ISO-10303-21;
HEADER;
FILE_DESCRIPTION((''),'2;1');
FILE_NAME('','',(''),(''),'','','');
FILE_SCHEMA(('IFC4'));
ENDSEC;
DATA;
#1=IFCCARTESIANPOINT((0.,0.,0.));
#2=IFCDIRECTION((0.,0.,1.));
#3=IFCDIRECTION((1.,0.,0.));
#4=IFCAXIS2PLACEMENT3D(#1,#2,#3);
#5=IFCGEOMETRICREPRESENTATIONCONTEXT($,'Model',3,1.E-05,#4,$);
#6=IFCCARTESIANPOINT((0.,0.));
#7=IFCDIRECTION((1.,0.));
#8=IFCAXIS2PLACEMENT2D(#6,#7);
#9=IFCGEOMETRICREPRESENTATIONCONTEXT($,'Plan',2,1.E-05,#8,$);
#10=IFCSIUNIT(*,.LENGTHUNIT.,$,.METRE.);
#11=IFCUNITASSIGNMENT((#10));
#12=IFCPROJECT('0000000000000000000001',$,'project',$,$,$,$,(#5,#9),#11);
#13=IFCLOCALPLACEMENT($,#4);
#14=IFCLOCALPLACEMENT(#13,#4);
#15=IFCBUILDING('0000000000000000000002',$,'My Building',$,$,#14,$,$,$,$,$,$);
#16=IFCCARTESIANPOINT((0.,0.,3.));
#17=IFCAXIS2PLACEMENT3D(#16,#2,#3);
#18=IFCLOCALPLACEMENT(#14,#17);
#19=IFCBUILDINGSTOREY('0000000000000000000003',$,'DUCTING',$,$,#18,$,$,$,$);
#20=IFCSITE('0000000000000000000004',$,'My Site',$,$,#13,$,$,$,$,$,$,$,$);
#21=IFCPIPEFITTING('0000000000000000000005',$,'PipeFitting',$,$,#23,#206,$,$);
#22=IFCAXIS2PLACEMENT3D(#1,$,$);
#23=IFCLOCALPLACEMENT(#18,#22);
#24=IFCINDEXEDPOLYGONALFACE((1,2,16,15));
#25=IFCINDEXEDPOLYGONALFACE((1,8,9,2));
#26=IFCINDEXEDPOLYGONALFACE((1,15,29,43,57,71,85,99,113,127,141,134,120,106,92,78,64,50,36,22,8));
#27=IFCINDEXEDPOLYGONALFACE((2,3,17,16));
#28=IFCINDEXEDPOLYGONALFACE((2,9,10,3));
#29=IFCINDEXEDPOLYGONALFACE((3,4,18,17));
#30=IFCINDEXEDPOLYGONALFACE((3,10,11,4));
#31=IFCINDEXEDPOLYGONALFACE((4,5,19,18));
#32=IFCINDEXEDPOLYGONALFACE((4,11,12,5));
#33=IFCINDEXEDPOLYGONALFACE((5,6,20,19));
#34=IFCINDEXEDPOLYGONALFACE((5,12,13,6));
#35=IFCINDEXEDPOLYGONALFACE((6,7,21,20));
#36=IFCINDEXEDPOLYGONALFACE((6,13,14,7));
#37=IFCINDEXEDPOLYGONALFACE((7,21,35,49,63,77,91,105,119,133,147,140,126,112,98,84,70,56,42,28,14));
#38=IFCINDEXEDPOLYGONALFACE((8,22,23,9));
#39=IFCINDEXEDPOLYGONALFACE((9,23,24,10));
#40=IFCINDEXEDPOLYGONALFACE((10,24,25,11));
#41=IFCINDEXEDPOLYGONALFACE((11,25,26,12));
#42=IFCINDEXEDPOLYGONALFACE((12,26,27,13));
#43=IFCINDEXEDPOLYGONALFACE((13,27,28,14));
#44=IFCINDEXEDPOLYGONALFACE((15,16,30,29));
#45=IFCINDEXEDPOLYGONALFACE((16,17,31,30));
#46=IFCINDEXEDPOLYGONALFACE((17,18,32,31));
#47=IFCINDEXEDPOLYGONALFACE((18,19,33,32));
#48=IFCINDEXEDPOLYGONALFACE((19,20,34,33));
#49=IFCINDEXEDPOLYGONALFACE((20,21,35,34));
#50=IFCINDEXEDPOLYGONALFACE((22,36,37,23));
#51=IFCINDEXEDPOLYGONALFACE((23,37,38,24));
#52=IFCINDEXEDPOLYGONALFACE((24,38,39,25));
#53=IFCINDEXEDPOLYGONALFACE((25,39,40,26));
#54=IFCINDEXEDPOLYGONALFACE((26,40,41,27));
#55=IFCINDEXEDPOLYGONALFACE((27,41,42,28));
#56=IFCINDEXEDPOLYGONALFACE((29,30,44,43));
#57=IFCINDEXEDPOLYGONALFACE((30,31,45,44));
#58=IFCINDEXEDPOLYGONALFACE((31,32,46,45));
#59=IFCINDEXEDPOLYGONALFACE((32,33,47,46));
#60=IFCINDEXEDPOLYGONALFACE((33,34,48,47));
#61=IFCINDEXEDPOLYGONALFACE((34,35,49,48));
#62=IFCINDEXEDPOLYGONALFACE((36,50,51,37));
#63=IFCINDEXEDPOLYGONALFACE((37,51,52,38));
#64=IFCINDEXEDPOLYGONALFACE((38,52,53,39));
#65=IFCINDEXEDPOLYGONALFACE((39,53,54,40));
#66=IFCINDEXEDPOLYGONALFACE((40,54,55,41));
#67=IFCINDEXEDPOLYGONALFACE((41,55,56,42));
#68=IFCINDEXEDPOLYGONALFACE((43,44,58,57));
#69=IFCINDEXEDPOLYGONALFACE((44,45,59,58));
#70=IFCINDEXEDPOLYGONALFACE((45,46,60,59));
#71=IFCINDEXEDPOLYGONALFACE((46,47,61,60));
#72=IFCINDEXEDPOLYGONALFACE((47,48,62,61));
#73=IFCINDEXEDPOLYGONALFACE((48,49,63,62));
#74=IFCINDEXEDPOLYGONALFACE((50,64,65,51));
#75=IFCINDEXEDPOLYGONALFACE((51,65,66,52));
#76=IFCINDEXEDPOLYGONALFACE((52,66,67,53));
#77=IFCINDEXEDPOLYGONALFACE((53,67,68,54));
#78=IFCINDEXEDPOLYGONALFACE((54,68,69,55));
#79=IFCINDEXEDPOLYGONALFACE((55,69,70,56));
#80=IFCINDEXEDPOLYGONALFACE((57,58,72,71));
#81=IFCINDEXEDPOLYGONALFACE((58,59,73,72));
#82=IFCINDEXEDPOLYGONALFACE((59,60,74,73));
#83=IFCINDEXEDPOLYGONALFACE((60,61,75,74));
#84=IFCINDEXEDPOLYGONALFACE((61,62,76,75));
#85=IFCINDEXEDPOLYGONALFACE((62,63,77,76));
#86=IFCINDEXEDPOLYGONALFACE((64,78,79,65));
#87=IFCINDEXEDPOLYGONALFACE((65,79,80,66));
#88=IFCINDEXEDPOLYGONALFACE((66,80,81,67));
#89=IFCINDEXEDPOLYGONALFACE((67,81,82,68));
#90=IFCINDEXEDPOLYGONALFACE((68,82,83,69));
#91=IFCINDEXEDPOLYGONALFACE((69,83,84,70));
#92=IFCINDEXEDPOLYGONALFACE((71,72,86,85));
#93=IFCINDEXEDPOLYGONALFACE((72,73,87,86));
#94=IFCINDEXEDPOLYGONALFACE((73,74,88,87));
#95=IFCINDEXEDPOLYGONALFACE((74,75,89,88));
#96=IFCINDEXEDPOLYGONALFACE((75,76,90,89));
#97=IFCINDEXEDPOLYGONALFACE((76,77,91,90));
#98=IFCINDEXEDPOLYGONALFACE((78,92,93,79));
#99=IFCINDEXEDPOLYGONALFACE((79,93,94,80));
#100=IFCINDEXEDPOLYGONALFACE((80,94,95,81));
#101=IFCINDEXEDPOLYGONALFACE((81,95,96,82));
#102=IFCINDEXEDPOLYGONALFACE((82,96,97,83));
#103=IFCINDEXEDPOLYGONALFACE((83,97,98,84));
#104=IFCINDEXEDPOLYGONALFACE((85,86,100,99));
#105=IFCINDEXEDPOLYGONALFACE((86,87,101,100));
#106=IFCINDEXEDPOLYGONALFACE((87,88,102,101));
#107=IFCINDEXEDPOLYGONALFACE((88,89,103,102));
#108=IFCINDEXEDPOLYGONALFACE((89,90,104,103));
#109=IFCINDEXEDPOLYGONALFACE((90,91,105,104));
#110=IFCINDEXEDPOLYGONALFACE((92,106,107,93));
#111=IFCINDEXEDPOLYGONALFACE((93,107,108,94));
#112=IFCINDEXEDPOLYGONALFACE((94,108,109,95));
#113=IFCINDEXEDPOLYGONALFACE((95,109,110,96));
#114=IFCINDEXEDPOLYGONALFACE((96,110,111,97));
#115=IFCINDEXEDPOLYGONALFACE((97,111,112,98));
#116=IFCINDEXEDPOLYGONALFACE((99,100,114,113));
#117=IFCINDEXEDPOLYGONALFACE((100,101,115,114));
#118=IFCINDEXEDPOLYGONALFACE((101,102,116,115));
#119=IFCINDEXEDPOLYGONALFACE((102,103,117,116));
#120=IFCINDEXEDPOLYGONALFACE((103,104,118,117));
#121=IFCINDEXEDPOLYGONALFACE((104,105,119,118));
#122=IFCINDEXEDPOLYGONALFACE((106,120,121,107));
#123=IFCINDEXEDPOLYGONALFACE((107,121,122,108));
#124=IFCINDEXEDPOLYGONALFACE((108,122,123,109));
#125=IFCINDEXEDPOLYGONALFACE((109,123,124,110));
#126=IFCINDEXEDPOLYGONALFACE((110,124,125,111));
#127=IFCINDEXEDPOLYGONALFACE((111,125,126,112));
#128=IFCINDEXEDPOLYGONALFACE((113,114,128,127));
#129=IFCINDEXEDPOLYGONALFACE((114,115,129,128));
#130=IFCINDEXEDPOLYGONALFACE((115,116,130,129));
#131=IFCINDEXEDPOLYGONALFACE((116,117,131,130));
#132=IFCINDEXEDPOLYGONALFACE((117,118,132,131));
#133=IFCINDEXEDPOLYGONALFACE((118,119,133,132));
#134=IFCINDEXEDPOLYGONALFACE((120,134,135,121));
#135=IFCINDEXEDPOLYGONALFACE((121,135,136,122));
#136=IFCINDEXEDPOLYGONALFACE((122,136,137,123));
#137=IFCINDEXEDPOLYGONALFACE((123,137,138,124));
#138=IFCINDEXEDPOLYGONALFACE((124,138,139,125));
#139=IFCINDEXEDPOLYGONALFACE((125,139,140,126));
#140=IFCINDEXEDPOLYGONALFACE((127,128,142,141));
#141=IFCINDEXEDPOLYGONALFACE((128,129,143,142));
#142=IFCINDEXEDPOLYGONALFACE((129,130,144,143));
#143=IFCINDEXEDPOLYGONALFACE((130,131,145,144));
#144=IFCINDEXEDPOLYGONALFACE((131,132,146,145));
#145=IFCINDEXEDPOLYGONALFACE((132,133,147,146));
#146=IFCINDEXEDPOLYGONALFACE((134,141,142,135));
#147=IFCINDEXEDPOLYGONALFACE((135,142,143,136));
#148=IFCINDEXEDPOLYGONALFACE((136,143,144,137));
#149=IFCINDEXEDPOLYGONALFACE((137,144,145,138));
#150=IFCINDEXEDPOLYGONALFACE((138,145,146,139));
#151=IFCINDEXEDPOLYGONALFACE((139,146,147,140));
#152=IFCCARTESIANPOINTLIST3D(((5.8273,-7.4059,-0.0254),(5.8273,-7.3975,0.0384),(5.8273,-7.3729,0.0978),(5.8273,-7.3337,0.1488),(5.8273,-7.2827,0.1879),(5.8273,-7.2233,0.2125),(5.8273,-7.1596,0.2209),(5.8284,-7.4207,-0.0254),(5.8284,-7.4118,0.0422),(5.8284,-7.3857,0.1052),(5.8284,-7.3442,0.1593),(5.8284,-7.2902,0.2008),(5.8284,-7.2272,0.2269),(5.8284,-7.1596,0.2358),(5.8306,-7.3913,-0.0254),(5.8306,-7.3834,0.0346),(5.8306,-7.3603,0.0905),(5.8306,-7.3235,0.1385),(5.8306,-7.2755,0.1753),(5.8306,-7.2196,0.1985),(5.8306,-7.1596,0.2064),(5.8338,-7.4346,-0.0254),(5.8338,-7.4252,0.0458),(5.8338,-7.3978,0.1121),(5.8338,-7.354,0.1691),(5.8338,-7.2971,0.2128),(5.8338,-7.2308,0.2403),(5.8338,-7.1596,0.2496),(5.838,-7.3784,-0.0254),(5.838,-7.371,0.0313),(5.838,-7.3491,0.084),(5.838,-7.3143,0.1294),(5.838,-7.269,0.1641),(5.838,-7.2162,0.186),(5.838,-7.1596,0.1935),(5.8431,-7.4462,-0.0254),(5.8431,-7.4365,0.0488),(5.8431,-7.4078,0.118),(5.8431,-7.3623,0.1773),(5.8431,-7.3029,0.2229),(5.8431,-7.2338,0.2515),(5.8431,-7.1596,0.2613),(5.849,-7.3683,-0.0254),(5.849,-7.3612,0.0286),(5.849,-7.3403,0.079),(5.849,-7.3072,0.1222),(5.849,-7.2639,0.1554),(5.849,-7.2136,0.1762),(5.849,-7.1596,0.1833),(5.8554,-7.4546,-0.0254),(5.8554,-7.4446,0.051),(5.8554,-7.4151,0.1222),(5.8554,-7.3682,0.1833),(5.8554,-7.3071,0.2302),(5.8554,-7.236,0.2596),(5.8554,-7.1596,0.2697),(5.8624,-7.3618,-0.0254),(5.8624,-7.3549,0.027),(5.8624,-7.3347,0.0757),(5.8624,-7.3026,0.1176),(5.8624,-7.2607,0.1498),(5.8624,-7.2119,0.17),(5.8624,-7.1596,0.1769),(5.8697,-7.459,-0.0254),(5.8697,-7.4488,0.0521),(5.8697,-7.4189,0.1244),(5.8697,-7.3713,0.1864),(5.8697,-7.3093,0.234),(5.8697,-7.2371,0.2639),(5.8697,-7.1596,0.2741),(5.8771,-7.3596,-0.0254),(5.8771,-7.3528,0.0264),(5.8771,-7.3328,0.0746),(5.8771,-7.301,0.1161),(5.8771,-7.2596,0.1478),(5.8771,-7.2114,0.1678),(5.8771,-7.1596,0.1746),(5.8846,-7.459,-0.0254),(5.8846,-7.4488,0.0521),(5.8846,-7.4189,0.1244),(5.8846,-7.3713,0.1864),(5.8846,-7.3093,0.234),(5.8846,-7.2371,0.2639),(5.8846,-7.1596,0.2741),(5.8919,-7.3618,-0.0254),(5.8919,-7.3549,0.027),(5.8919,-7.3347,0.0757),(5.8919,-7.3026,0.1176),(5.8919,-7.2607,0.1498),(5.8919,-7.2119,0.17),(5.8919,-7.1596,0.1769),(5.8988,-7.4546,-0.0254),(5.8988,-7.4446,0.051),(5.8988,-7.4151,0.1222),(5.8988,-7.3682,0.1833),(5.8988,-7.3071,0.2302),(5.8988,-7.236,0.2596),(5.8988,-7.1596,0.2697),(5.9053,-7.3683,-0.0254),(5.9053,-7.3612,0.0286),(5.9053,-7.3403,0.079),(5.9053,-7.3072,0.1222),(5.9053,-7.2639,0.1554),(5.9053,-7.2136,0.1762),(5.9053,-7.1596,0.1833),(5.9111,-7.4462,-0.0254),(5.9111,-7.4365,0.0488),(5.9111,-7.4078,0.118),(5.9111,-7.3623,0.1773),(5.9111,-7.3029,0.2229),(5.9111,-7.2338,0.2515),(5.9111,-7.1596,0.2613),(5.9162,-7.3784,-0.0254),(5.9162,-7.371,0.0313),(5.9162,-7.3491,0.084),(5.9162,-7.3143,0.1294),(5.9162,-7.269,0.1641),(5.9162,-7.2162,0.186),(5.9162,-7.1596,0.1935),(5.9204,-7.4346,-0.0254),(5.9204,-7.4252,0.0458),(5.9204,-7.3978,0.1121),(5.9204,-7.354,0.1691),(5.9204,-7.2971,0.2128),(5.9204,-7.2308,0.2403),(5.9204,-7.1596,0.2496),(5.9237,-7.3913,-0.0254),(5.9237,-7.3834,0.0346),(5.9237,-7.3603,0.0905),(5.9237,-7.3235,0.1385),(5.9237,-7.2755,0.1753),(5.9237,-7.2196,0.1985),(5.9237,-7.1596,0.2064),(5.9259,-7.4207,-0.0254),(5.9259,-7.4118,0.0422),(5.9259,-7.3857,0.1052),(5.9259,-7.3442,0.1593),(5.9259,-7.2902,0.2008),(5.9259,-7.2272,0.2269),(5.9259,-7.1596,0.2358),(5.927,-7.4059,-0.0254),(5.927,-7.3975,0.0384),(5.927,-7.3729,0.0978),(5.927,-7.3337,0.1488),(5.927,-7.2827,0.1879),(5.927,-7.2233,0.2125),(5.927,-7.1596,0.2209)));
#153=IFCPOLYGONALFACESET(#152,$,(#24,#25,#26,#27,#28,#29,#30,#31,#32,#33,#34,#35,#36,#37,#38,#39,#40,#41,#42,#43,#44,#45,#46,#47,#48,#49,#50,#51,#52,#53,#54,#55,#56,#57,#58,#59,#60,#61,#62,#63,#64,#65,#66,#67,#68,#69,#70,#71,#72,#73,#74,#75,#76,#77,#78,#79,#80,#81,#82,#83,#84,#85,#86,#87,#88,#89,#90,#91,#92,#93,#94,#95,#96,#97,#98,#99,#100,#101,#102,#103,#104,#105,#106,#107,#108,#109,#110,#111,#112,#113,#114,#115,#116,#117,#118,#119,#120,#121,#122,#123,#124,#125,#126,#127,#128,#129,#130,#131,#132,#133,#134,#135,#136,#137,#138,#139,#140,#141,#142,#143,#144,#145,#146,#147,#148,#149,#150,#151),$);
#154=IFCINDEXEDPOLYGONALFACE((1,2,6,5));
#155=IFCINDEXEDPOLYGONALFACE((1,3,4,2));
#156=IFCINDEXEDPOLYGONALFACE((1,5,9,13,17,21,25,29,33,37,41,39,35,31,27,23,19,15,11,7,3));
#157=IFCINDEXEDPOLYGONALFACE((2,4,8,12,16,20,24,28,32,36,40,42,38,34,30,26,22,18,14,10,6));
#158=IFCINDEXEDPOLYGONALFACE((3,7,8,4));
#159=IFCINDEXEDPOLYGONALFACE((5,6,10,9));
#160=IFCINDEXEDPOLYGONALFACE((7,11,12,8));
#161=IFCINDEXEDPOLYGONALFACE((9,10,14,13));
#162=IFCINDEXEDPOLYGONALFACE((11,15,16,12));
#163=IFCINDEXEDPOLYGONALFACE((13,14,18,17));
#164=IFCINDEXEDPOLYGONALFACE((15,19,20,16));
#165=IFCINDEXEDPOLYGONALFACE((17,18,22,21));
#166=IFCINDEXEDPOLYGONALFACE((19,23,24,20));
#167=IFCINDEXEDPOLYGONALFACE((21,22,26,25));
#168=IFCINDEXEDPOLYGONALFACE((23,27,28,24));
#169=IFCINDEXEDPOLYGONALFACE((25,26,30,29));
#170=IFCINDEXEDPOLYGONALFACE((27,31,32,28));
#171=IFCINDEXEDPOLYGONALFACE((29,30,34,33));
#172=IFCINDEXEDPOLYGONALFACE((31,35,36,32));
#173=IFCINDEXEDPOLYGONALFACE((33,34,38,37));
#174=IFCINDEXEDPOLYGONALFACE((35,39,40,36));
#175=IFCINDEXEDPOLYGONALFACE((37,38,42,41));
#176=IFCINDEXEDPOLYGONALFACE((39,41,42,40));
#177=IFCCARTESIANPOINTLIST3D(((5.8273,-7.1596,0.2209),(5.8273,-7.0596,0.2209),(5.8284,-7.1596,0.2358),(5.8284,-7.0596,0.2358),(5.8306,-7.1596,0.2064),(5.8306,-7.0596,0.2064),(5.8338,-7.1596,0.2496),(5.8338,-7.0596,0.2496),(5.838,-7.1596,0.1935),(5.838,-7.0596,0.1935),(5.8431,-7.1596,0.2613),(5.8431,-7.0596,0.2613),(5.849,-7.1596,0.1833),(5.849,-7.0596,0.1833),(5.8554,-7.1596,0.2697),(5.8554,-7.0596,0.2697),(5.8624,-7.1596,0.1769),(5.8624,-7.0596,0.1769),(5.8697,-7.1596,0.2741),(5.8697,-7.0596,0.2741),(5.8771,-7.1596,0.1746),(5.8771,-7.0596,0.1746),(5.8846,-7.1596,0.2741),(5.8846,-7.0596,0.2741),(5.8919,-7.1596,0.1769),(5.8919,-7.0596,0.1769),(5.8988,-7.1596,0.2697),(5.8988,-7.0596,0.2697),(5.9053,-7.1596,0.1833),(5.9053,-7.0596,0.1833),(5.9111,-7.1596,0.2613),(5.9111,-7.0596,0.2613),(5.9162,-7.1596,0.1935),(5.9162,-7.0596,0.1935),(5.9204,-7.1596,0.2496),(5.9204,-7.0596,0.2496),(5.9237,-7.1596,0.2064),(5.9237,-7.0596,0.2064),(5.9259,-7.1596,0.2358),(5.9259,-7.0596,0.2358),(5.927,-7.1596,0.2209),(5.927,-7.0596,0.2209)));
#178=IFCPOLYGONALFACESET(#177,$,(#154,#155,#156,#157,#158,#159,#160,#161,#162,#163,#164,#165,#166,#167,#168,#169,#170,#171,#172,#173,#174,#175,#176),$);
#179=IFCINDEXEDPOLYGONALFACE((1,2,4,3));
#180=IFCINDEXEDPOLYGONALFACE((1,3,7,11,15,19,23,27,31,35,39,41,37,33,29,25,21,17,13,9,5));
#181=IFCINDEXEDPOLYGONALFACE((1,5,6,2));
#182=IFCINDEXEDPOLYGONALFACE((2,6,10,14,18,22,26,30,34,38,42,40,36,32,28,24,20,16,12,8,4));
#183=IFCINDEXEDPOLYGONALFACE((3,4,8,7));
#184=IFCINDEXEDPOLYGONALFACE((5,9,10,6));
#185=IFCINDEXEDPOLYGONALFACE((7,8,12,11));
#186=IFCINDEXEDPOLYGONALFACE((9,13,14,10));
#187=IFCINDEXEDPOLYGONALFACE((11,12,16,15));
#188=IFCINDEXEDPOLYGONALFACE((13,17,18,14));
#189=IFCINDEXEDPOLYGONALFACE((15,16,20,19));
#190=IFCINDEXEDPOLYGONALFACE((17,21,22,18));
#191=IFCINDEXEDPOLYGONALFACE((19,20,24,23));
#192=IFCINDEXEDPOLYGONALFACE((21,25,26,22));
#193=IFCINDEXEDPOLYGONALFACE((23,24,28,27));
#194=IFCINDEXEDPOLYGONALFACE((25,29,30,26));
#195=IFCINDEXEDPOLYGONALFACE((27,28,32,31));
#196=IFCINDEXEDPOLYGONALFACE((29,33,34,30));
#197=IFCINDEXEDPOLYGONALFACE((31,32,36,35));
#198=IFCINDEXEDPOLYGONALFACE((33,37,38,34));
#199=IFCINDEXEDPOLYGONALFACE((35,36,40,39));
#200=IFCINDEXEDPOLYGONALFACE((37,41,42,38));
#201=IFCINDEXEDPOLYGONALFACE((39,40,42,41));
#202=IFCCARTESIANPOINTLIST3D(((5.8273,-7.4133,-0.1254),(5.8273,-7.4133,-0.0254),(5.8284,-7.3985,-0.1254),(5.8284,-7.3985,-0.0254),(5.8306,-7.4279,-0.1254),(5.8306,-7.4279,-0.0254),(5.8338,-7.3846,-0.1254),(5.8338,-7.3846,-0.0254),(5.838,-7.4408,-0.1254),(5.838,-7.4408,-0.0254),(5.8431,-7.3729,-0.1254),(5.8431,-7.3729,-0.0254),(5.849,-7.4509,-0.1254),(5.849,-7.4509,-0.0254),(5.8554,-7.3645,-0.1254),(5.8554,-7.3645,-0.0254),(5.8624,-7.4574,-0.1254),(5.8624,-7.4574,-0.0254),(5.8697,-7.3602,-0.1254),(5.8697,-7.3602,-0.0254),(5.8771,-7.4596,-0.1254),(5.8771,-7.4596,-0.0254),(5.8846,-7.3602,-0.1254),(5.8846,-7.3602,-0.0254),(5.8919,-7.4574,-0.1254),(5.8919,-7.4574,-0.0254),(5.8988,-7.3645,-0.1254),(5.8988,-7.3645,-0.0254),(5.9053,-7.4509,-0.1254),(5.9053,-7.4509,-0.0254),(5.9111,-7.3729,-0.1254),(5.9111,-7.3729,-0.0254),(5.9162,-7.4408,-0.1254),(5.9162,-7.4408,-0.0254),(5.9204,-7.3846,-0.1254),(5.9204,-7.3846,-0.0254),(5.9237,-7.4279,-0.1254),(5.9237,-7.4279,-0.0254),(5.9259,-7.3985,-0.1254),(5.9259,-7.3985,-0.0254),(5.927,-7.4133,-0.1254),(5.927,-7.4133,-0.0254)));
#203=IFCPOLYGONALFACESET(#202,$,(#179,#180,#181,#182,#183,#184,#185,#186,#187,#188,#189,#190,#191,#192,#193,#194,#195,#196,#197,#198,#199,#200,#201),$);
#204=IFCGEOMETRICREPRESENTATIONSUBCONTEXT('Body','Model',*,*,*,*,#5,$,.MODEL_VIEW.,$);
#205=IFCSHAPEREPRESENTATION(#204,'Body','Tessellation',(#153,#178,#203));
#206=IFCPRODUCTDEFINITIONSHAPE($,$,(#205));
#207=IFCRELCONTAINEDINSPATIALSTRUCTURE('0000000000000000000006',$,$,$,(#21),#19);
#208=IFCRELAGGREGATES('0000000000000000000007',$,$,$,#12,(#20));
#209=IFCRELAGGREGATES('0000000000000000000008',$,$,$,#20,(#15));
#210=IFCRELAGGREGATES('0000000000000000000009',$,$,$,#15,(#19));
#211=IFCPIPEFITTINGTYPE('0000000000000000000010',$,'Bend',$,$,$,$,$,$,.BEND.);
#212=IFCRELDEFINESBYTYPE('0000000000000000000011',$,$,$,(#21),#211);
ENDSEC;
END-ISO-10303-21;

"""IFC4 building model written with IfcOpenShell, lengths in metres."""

from ifc_helpers import new_model, entity, si_unit, frame, origin_with_axes, origin_2d_with_axis, place, context, subcontext, project, spatial, circle, extrude, source, transform, mapped, type_object, type_shapes, element, save


model = new_model("IFC4")

# Units and contexts
model_context = context("Model", 3, precision=1e-05, world=origin_with_axes())
plan_context = context("Plan", 2, precision=1e-05, world=origin_2d_with_axis())
body_context = subcontext(model_context, "Body", "Model", "MODEL_VIEW")
ifc_project = project(units=[si_unit("LENGTHUNIT", "METRE")], contexts=[model_context, plan_context])

# Site, building, storey
site_placement = place(None, origin_with_axes())
site = spatial("IfcSite", under=ifc_project, at=site_placement, Name="My Site")
building_placement = place(site_placement, origin_with_axes())
building = spatial("IfcBuilding", under=site, at=building_placement, Name="My Building")
storey_placement = place(building_placement, frame((0.0, 0.0, 3.0), z_axis=(0.0, 0.0, 1.0), x_axis=(1.0, 0.0, 0.0)))
storey = spatial("IfcBuildingStorey", under=building, at=storey_placement, Name="DUCTING")

# Pipe fitting
pipe_fitting_type = type_object("IfcPipeFittingType", Name="Bend", PredefinedType="BEND")
shared_shape_1 = source(origin_with_axes(), body_context, "Body", "SolidModel", [
    entity("IfcSweptDiskSolid", entity("IfcIndexedPolyCurve", entity("IfcCartesianPointList3D", [[0.0, 0.0, 0.1], [0.0732, 0.0, 0.2768], [0.25, 0.0, 0.35]]), [entity("IfcArcIndex", [1, 2, 3])]), 0.05),
    extrude(circle(Radius=0.05), origin_with_axes(), (0.0, 0.0, 1.0), 0.1),
    extrude(circle(Radius=0.05), frame((0.25, 0.0, 0.35), z_axis=(1.0, 0.0, 0.0), x_axis=(0.0, 0.0, 1.0)), (0.0, 0.0, 1.0), 0.1),
])
type_shapes(pipe_fitting_type, [shared_shape_1])
for number, where, z_axis, x_axis, name in (
    (1, (5.8771, -7.0596, 0.2246), (0.0, -1.0, 0.0), (0.0, 0.0, -1.0), "PipeFitting"),
):
    element("IfcPipeFitting", number, at=place(storey_placement, frame(where, z_axis=z_axis, x_axis=x_axis)), inside=storey, type_object=pipe_fitting_type, Name=name, context=body_context, shape_type="MappedRepresentation", body=[
        mapped(shared_shape_1, transform((0.0, 0.0, 0.0), x_axis=(1.0, 0.0, 0.0), y_axis=(0.0, 1.0, 0.0), z_axis=(0.0, 0.0, 1.0), scale=1.0)),
    ])

save(model, "model.ifc")
